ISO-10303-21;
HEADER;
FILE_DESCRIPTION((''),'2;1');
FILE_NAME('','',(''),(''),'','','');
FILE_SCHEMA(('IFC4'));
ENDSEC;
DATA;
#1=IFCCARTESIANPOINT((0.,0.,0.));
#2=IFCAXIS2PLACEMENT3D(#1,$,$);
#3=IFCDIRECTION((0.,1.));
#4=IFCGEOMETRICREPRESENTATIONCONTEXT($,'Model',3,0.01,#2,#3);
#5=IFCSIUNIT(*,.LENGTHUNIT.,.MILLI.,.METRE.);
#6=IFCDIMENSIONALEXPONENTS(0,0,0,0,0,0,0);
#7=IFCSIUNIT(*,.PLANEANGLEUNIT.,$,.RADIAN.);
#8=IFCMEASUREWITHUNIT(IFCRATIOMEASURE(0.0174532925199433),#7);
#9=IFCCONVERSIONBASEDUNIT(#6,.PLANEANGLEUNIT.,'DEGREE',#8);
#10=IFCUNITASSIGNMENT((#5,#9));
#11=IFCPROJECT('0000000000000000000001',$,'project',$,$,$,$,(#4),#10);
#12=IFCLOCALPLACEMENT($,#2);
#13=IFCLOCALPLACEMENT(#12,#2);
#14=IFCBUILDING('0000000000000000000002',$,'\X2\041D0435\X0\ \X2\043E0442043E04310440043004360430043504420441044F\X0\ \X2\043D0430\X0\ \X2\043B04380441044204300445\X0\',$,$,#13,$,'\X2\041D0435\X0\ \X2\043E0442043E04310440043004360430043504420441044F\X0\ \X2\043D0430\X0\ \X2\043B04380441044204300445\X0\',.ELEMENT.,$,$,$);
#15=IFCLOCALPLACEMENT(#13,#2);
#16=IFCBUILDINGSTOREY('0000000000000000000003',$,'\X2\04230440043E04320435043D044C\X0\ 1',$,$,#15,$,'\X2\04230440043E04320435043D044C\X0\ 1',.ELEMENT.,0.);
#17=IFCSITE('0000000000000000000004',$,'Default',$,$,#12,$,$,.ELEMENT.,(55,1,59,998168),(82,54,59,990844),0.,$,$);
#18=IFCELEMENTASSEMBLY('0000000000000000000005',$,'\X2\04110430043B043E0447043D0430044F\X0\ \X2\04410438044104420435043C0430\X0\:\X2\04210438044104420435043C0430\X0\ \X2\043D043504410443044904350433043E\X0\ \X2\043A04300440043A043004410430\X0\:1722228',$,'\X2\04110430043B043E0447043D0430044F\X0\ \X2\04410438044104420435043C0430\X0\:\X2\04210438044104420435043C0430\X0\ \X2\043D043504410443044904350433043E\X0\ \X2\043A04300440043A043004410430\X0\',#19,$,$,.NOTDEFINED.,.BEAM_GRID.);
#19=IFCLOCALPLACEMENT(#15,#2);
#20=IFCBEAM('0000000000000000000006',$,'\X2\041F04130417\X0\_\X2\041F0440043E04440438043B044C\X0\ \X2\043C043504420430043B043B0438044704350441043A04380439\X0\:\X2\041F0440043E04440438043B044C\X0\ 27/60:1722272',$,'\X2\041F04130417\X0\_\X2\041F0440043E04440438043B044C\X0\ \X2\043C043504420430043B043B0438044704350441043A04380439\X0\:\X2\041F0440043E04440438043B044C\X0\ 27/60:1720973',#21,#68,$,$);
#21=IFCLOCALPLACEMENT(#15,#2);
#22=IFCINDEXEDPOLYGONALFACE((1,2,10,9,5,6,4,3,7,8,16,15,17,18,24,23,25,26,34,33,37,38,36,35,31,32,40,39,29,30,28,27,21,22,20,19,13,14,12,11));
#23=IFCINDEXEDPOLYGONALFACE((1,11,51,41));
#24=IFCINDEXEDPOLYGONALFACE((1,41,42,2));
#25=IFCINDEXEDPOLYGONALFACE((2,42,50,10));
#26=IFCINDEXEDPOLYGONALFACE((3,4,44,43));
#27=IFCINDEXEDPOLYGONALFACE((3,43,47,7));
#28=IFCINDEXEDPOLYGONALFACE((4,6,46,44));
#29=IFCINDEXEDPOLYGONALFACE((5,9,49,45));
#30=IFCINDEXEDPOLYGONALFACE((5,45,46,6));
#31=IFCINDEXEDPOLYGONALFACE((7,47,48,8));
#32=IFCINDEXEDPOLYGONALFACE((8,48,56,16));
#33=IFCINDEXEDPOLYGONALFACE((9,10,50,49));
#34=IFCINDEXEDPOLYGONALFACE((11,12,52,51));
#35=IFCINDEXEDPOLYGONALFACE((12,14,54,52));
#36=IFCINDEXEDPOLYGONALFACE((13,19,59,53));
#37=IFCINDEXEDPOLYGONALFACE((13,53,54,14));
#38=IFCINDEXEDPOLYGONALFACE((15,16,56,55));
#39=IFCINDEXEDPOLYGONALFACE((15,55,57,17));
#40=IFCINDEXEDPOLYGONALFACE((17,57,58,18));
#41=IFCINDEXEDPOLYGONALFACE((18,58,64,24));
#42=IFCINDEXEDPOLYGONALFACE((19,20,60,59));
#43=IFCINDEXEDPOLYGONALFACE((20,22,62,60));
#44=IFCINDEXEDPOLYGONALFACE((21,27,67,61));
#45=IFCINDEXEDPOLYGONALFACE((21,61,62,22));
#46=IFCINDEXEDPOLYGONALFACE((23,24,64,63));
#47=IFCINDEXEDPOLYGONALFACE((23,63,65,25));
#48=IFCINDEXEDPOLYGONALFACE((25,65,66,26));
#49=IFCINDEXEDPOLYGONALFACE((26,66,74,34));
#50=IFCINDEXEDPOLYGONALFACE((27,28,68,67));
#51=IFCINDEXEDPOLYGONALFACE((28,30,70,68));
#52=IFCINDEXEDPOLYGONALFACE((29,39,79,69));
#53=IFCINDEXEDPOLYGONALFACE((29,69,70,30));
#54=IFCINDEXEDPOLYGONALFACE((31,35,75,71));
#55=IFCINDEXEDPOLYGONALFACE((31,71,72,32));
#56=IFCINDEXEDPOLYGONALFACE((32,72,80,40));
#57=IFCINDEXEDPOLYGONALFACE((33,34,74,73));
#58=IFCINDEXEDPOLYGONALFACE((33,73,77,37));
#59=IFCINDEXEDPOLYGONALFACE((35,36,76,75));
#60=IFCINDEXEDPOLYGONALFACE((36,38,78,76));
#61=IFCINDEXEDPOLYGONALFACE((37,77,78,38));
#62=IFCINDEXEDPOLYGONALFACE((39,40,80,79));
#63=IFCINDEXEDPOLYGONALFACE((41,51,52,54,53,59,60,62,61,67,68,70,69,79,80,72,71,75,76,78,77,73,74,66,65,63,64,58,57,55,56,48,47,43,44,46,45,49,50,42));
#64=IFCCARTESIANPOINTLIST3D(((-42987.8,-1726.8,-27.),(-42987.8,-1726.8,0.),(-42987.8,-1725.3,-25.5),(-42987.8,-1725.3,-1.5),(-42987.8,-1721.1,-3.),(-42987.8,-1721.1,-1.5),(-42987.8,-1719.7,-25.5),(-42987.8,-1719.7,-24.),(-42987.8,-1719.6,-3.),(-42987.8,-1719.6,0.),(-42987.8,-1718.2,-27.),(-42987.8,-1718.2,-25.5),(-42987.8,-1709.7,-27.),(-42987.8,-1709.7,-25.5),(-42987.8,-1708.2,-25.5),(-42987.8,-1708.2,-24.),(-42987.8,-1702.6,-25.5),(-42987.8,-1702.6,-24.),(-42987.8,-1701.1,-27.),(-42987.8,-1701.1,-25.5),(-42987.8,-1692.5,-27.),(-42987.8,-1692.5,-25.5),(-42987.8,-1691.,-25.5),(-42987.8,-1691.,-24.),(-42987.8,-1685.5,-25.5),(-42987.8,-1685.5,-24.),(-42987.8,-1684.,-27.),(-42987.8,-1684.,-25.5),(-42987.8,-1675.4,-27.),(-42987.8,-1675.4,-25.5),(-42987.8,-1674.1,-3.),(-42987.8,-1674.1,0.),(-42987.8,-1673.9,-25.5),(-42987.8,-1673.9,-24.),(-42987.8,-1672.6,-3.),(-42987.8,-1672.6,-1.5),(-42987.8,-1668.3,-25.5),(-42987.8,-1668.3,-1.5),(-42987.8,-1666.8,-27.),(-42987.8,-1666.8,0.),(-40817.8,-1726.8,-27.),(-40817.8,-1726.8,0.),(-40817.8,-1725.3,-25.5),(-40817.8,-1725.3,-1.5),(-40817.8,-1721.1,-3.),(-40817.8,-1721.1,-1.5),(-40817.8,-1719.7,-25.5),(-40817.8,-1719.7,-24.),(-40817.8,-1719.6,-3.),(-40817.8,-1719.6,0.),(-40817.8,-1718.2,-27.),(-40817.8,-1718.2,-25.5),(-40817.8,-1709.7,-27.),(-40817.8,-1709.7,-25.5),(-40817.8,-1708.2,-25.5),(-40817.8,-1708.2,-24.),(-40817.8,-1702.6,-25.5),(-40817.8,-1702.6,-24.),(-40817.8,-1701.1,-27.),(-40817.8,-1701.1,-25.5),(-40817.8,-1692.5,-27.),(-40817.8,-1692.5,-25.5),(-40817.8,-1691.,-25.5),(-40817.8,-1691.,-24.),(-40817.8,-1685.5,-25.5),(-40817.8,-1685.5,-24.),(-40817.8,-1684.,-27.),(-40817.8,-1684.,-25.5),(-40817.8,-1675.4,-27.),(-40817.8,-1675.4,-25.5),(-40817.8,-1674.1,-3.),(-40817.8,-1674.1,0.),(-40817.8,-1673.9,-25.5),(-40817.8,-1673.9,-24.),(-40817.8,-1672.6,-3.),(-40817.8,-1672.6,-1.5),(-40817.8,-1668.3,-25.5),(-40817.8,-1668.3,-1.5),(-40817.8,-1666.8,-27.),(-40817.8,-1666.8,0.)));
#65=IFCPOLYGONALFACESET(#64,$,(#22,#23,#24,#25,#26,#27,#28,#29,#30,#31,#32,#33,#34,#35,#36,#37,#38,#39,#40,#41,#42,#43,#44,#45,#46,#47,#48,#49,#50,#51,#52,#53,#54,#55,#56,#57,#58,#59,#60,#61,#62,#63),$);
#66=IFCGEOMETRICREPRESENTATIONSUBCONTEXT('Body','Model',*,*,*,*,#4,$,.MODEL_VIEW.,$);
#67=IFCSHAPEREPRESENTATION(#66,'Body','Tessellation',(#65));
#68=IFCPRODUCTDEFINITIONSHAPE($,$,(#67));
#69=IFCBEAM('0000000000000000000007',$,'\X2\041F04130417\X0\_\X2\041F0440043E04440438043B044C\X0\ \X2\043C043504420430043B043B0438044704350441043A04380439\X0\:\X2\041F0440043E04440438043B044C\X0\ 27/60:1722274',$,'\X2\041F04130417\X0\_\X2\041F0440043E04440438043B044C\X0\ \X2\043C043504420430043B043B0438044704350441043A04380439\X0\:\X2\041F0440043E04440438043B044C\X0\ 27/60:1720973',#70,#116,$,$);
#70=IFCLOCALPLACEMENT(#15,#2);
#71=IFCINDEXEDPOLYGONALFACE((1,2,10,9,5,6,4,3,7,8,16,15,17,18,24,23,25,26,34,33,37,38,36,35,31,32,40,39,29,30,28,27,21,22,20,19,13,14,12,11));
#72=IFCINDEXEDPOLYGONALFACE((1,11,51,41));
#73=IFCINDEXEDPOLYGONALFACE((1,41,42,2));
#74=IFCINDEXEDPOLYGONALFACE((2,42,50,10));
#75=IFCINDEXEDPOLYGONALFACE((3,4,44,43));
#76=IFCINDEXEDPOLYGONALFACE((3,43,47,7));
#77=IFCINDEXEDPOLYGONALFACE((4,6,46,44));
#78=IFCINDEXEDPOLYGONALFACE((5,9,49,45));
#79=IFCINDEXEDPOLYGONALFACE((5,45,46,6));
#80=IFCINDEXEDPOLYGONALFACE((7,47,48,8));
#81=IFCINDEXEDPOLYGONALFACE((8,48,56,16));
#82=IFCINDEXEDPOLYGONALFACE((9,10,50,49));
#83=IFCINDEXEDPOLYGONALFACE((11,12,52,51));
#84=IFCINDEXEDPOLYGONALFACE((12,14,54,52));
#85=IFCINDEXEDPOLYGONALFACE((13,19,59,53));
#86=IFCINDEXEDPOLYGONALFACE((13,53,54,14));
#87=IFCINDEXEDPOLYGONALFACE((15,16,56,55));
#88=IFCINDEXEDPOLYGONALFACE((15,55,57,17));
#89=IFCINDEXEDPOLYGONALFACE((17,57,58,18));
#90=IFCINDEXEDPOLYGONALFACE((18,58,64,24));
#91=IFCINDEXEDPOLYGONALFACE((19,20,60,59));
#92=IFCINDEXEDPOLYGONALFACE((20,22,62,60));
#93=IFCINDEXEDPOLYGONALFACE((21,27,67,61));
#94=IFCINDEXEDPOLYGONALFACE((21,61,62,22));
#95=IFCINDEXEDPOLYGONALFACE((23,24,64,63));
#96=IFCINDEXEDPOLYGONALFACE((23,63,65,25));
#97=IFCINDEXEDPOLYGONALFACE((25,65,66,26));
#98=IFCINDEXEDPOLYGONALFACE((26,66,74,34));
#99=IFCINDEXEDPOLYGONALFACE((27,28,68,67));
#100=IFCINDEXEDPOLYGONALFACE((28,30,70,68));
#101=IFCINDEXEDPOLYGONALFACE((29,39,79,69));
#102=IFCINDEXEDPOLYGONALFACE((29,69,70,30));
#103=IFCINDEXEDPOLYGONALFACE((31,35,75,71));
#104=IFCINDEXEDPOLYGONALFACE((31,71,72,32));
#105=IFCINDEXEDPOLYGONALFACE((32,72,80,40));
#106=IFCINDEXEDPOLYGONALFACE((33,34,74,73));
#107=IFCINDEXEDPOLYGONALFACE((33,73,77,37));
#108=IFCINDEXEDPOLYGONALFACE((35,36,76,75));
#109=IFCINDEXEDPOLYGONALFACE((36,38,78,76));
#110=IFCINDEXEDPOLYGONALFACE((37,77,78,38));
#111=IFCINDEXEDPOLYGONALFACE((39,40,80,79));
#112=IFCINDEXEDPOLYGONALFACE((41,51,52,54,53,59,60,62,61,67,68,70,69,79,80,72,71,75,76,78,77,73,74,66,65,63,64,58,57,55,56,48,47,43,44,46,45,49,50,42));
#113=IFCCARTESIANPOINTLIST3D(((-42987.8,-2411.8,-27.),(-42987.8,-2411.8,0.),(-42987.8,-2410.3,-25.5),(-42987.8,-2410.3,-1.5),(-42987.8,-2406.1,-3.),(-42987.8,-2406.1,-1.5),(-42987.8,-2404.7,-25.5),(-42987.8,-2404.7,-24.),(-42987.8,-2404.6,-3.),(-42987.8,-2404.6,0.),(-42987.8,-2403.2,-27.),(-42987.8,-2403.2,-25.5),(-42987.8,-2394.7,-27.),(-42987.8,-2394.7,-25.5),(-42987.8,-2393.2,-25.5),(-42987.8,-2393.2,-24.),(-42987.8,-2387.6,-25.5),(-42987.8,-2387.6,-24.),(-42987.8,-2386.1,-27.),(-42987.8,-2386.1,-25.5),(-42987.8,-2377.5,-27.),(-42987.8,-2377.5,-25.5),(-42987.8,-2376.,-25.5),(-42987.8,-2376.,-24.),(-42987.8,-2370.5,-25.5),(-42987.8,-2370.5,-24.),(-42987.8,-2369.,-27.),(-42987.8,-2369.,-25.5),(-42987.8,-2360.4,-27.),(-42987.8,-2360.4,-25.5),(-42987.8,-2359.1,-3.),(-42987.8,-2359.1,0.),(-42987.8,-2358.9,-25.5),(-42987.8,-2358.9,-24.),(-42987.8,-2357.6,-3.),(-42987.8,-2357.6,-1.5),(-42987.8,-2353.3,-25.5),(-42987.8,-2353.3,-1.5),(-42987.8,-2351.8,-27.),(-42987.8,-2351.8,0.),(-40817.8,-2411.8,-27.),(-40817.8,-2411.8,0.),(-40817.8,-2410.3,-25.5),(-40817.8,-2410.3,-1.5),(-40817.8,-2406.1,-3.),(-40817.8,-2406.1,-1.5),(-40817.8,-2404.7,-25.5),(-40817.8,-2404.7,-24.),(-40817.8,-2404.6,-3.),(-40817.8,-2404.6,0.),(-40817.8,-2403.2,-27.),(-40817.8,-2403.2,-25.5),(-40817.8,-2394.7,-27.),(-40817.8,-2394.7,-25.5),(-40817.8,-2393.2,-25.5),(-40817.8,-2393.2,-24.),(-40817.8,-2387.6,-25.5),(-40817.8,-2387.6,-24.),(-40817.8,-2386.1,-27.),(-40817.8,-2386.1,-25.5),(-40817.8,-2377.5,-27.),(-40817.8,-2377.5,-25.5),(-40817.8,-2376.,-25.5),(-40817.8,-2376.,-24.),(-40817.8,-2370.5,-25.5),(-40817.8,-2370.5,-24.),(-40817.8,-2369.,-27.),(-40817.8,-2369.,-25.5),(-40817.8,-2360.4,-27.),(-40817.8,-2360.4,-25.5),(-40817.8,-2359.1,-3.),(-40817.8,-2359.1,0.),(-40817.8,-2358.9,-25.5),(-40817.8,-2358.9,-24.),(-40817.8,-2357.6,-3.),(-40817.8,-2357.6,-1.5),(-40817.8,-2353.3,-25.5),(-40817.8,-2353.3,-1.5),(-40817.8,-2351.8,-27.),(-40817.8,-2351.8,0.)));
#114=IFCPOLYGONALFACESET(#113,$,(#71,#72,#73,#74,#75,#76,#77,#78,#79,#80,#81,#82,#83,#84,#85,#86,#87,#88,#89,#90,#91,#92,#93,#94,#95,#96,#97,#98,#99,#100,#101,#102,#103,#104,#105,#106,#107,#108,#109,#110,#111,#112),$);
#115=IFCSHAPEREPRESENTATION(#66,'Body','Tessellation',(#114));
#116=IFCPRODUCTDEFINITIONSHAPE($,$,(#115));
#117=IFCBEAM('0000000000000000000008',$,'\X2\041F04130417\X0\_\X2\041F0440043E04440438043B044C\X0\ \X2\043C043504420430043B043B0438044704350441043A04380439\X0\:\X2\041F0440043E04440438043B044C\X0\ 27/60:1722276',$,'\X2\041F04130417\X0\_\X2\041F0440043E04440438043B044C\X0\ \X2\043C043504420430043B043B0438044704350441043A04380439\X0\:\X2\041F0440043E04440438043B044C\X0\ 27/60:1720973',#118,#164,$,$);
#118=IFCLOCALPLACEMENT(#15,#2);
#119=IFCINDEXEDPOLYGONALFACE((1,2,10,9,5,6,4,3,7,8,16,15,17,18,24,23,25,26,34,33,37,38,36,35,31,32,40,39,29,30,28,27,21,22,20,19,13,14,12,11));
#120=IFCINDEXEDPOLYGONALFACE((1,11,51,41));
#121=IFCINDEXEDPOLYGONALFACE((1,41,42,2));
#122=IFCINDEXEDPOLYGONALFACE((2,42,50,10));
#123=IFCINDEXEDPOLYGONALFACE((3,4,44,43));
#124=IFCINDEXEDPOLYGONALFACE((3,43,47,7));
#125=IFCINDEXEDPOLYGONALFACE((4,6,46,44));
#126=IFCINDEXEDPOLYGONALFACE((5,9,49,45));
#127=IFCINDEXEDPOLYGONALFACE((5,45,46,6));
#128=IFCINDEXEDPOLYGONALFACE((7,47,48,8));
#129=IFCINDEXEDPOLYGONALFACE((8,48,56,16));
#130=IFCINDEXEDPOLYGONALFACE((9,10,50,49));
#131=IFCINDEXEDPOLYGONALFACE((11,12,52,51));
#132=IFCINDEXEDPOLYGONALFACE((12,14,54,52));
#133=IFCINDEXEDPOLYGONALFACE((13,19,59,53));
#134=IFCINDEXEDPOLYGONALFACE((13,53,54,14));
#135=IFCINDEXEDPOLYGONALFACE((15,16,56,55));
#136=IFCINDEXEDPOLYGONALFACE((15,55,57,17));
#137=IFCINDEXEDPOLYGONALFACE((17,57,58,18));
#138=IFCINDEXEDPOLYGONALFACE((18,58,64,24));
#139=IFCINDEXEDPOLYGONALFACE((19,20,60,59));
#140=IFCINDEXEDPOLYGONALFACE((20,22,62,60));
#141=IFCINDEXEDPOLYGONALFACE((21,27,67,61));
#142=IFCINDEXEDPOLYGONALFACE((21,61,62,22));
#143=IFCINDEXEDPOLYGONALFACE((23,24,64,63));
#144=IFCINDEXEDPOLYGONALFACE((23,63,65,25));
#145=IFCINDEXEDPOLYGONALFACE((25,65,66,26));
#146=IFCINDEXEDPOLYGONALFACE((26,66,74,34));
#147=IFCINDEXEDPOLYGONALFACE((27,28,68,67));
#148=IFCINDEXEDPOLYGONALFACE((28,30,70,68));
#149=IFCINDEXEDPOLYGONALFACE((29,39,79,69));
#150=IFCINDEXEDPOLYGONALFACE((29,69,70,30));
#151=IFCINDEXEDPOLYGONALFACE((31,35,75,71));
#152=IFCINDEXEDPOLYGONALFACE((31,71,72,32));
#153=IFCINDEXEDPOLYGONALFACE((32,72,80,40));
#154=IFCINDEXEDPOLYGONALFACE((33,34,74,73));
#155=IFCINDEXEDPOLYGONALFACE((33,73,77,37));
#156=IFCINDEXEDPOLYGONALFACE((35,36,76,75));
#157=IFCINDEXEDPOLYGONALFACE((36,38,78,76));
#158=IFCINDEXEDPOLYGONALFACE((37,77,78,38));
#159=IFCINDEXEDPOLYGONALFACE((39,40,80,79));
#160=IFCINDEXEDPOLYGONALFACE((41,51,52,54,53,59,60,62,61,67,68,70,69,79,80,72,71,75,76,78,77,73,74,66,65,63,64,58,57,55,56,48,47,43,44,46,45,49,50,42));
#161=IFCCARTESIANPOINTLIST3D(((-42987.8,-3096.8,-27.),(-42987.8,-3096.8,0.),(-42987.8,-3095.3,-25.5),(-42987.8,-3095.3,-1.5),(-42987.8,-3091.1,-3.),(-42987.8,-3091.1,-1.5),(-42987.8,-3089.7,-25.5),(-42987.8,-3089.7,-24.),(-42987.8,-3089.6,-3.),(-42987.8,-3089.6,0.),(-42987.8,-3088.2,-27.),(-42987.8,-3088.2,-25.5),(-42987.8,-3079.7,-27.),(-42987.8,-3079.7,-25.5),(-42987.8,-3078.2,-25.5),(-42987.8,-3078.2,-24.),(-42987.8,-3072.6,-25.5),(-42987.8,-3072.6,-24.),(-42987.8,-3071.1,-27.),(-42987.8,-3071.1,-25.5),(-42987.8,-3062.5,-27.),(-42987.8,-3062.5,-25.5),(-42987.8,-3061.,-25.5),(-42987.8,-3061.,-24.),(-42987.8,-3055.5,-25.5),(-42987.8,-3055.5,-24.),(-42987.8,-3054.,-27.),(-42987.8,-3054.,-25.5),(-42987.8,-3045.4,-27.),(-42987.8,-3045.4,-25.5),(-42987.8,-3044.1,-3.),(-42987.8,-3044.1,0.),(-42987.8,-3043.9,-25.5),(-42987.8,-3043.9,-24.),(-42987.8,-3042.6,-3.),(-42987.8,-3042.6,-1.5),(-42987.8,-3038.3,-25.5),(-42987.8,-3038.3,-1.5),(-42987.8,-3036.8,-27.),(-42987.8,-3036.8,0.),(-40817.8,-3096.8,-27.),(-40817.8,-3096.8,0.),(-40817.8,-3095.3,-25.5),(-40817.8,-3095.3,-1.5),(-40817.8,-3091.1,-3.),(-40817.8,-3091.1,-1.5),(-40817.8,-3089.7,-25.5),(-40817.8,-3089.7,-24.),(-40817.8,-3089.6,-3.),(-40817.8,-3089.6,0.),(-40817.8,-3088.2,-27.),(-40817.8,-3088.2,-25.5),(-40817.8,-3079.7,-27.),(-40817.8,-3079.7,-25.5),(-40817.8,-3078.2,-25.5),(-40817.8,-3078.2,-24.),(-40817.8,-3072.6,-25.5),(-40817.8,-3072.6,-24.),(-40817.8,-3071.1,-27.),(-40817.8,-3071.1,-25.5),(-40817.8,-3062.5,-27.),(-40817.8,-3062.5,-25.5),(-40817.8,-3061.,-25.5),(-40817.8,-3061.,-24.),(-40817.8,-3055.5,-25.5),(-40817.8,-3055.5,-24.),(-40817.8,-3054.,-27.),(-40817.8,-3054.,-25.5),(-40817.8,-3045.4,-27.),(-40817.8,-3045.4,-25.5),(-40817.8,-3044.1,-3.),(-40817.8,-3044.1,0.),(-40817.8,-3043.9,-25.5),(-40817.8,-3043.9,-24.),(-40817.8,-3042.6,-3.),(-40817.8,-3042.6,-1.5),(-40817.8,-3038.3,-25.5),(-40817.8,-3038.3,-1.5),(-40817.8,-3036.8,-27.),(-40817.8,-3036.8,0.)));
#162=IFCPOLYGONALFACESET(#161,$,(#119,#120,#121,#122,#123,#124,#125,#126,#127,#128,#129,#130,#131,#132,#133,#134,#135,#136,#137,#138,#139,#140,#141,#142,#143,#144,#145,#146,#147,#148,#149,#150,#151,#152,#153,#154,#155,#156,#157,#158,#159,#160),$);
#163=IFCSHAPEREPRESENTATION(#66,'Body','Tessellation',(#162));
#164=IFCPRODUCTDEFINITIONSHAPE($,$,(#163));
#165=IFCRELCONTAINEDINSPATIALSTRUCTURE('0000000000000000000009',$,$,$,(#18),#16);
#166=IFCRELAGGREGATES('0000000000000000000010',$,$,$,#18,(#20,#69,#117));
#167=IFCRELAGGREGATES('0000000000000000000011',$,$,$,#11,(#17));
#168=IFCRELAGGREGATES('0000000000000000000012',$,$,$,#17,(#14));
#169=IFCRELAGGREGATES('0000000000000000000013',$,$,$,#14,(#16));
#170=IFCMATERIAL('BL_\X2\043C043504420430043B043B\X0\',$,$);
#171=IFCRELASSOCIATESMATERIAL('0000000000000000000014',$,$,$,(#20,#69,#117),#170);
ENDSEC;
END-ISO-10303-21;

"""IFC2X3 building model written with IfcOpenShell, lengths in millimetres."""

from ifc_helpers import new_model, entity, si_unit, converted_unit, direction, frame, origin, place, context, subcontext, project, spatial, polyline, outline, extrude, material, element, aggregate, save


model = new_model("IFC2X3")

# Units and contexts
model_context = context("Model", 3, precision=0.01, world=origin(), true_north=direction((0.0, 1.0)))
body_context = subcontext(model_context, "Body", "Model", "MODEL_VIEW")
ifc_project = project(units=[si_unit("LENGTHUNIT", "METRE", prefix="MILLI"), converted_unit("PLANEANGLEUNIT", "DEGREE", entity("IfcRatioMeasure", 0.0174532925199433), si_unit("PLANEANGLEUNIT", "RADIAN"), dimensions=[0, 0, 0, 0, 0, 0, 0])], contexts=[model_context])

# Site, building, storey
site_placement = place(None, origin())
site = spatial("IfcSite", under=ifc_project, at=site_placement, Name="Default", CompositionType="ELEMENT", RefLatitude=(55, 1, 59, 998168), RefLongitude=(82, 54, 59, 990844), RefElevation=0.0)
building_placement = place(site_placement, origin())
building = spatial("IfcBuilding", under=site, at=building_placement, Name="Не отображается на листах", LongName="Не отображается на листах", CompositionType="ELEMENT")
storey_placement = place(building_placement, frame((0.0, 0.0, 0.0)))
storey = spatial("IfcBuildingStorey", under=building, at=storey_placement, Name="Уровень 1", LongName="Уровень 1", CompositionType="ELEMENT", Elevation=0.0)

# Element assembly, beams
ifc_material_1 = material(Name="BL_металл")
assembly_1_placement = place(storey_placement, origin())
assembly_1 = element("IfcElementAssembly", 1, at=assembly_1_placement, inside=storey, Name="Балочная система:Система несущего каркаса:1722228", ObjectType="Балочная система:Система несущего каркаса", AssemblyPlace="NOTDEFINED", PredefinedType="BEAM_GRID")
beam_1_placement = place(assembly_1_placement, frame((-42987.8, -1696.8, 0.0)))
beam_1 = element("IfcBeam", 2, at=beam_1_placement, material=ifc_material_1, Name="ПГЗ_Профиль металлический:Профиль 27/60:1722272", ObjectType="ПГЗ_Профиль металлический:Профиль 27/60:1720973", context=body_context, shape_type="SweptSolid", body=[
    extrude(outline(polyline([(-18.4, -30.0), (8.6, -30.0), (8.6, -21.4), (7.1, -21.4), (7.1, -12.9), (8.6, -12.9), (8.6, -4.3), (7.1, -4.3), (7.1, 4.3), (8.6, 4.3), (8.6, 12.9), (7.1, 12.9), (7.1, 21.4), (8.6, 21.4), (8.6, 30.0), (-18.4, 30.0), (-18.4, 22.7), (-15.4, 22.7), (-15.4, 24.2), (-16.9, 24.2), (-16.9, 28.5), (7.1, 28.5), (7.1, 22.9), (5.6, 22.9), (5.6, 11.4), (7.1, 11.4), (7.1, 5.8), (5.6, 5.8), (5.6, -5.8), (7.1, -5.8), (7.1, -11.4), (5.6, -11.4), (5.6, -22.9), (7.1, -22.9), (7.1, -28.5), (-16.9, -28.5), (-16.9, -24.2), (-15.4, -24.2), (-15.4, -22.7), (-18.4, -22.7), (-18.4, -30.0)])), frame((0.0, 0.0, -18.4), z_axis=(1.0, 0.0, 0.0), x_axis=(0.0, 0.0, -1.0)), (0.0, 0.0, 1.0), 2170.0),
])
beam_2_placement = place(assembly_1_placement, frame((-42987.8, -2381.8, 0.0)))
beam_2 = element("IfcBeam", 3, at=beam_2_placement, material=ifc_material_1, Name="ПГЗ_Профиль металлический:Профиль 27/60:1722274", ObjectType="ПГЗ_Профиль металлический:Профиль 27/60:1720973", context=body_context, shape_type="SweptSolid", body=[
    extrude(outline(polyline([(-18.4, -30.0), (8.6, -30.0), (8.6, -21.4), (7.1, -21.4), (7.1, -12.9), (8.6, -12.9), (8.6, -4.3), (7.1, -4.3), (7.1, 4.3), (8.6, 4.3), (8.6, 12.9), (7.1, 12.9), (7.1, 21.4), (8.6, 21.4), (8.6, 30.0), (-18.4, 30.0), (-18.4, 22.7), (-15.4, 22.7), (-15.4, 24.2), (-16.9, 24.2), (-16.9, 28.5), (7.1, 28.5), (7.1, 22.9), (5.6, 22.9), (5.6, 11.4), (7.1, 11.4), (7.1, 5.8), (5.6, 5.8), (5.6, -5.8), (7.1, -5.8), (7.1, -11.4), (5.6, -11.4), (5.6, -22.9), (7.1, -22.9), (7.1, -28.5), (-16.9, -28.5), (-16.9, -24.2), (-15.4, -24.2), (-15.4, -22.7), (-18.4, -22.7), (-18.4, -30.0)])), frame((0.0, 0.0, -18.4), z_axis=(1.0, 0.0, 0.0), x_axis=(0.0, 0.0, -1.0)), (0.0, 0.0, 1.0), 2170.0),
])
beam_3_placement = place(assembly_1_placement, frame((-42987.8, -3066.8, 0.0)))
beam_3 = element("IfcBeam", 4, at=beam_3_placement, material=ifc_material_1, Name="ПГЗ_Профиль металлический:Профиль 27/60:1722276", ObjectType="ПГЗ_Профиль металлический:Профиль 27/60:1720973", context=body_context, shape_type="SweptSolid", body=[
    extrude(outline(polyline([(-18.4, -30.0), (8.6, -30.0), (8.6, -21.4), (7.1, -21.4), (7.1, -12.9), (8.6, -12.9), (8.6, -4.3), (7.1, -4.3), (7.1, 4.3), (8.6, 4.3), (8.6, 12.9), (7.1, 12.9), (7.1, 21.4), (8.6, 21.4), (8.6, 30.0), (-18.4, 30.0), (-18.4, 22.7), (-15.4, 22.7), (-15.4, 24.2), (-16.9, 24.2), (-16.9, 28.5), (7.1, 28.5), (7.1, 22.9), (5.6, 22.9), (5.6, 11.4), (7.1, 11.4), (7.1, 5.8), (5.6, 5.8), (5.6, -5.8), (7.1, -5.8), (7.1, -11.4), (5.6, -11.4), (5.6, -22.9), (7.1, -22.9), (7.1, -28.5), (-16.9, -28.5), (-16.9, -24.2), (-15.4, -24.2), (-15.4, -22.7), (-18.4, -22.7), (-18.4, -30.0)])), frame((0.0, 0.0, -18.4), z_axis=(1.0, 0.0, 0.0), x_axis=(0.0, 0.0, -1.0)), (0.0, 0.0, 1.0), 2170.0),
])
aggregate(assembly_1, [beam_1, beam_2, beam_3])

save(model, "model.ifc")
